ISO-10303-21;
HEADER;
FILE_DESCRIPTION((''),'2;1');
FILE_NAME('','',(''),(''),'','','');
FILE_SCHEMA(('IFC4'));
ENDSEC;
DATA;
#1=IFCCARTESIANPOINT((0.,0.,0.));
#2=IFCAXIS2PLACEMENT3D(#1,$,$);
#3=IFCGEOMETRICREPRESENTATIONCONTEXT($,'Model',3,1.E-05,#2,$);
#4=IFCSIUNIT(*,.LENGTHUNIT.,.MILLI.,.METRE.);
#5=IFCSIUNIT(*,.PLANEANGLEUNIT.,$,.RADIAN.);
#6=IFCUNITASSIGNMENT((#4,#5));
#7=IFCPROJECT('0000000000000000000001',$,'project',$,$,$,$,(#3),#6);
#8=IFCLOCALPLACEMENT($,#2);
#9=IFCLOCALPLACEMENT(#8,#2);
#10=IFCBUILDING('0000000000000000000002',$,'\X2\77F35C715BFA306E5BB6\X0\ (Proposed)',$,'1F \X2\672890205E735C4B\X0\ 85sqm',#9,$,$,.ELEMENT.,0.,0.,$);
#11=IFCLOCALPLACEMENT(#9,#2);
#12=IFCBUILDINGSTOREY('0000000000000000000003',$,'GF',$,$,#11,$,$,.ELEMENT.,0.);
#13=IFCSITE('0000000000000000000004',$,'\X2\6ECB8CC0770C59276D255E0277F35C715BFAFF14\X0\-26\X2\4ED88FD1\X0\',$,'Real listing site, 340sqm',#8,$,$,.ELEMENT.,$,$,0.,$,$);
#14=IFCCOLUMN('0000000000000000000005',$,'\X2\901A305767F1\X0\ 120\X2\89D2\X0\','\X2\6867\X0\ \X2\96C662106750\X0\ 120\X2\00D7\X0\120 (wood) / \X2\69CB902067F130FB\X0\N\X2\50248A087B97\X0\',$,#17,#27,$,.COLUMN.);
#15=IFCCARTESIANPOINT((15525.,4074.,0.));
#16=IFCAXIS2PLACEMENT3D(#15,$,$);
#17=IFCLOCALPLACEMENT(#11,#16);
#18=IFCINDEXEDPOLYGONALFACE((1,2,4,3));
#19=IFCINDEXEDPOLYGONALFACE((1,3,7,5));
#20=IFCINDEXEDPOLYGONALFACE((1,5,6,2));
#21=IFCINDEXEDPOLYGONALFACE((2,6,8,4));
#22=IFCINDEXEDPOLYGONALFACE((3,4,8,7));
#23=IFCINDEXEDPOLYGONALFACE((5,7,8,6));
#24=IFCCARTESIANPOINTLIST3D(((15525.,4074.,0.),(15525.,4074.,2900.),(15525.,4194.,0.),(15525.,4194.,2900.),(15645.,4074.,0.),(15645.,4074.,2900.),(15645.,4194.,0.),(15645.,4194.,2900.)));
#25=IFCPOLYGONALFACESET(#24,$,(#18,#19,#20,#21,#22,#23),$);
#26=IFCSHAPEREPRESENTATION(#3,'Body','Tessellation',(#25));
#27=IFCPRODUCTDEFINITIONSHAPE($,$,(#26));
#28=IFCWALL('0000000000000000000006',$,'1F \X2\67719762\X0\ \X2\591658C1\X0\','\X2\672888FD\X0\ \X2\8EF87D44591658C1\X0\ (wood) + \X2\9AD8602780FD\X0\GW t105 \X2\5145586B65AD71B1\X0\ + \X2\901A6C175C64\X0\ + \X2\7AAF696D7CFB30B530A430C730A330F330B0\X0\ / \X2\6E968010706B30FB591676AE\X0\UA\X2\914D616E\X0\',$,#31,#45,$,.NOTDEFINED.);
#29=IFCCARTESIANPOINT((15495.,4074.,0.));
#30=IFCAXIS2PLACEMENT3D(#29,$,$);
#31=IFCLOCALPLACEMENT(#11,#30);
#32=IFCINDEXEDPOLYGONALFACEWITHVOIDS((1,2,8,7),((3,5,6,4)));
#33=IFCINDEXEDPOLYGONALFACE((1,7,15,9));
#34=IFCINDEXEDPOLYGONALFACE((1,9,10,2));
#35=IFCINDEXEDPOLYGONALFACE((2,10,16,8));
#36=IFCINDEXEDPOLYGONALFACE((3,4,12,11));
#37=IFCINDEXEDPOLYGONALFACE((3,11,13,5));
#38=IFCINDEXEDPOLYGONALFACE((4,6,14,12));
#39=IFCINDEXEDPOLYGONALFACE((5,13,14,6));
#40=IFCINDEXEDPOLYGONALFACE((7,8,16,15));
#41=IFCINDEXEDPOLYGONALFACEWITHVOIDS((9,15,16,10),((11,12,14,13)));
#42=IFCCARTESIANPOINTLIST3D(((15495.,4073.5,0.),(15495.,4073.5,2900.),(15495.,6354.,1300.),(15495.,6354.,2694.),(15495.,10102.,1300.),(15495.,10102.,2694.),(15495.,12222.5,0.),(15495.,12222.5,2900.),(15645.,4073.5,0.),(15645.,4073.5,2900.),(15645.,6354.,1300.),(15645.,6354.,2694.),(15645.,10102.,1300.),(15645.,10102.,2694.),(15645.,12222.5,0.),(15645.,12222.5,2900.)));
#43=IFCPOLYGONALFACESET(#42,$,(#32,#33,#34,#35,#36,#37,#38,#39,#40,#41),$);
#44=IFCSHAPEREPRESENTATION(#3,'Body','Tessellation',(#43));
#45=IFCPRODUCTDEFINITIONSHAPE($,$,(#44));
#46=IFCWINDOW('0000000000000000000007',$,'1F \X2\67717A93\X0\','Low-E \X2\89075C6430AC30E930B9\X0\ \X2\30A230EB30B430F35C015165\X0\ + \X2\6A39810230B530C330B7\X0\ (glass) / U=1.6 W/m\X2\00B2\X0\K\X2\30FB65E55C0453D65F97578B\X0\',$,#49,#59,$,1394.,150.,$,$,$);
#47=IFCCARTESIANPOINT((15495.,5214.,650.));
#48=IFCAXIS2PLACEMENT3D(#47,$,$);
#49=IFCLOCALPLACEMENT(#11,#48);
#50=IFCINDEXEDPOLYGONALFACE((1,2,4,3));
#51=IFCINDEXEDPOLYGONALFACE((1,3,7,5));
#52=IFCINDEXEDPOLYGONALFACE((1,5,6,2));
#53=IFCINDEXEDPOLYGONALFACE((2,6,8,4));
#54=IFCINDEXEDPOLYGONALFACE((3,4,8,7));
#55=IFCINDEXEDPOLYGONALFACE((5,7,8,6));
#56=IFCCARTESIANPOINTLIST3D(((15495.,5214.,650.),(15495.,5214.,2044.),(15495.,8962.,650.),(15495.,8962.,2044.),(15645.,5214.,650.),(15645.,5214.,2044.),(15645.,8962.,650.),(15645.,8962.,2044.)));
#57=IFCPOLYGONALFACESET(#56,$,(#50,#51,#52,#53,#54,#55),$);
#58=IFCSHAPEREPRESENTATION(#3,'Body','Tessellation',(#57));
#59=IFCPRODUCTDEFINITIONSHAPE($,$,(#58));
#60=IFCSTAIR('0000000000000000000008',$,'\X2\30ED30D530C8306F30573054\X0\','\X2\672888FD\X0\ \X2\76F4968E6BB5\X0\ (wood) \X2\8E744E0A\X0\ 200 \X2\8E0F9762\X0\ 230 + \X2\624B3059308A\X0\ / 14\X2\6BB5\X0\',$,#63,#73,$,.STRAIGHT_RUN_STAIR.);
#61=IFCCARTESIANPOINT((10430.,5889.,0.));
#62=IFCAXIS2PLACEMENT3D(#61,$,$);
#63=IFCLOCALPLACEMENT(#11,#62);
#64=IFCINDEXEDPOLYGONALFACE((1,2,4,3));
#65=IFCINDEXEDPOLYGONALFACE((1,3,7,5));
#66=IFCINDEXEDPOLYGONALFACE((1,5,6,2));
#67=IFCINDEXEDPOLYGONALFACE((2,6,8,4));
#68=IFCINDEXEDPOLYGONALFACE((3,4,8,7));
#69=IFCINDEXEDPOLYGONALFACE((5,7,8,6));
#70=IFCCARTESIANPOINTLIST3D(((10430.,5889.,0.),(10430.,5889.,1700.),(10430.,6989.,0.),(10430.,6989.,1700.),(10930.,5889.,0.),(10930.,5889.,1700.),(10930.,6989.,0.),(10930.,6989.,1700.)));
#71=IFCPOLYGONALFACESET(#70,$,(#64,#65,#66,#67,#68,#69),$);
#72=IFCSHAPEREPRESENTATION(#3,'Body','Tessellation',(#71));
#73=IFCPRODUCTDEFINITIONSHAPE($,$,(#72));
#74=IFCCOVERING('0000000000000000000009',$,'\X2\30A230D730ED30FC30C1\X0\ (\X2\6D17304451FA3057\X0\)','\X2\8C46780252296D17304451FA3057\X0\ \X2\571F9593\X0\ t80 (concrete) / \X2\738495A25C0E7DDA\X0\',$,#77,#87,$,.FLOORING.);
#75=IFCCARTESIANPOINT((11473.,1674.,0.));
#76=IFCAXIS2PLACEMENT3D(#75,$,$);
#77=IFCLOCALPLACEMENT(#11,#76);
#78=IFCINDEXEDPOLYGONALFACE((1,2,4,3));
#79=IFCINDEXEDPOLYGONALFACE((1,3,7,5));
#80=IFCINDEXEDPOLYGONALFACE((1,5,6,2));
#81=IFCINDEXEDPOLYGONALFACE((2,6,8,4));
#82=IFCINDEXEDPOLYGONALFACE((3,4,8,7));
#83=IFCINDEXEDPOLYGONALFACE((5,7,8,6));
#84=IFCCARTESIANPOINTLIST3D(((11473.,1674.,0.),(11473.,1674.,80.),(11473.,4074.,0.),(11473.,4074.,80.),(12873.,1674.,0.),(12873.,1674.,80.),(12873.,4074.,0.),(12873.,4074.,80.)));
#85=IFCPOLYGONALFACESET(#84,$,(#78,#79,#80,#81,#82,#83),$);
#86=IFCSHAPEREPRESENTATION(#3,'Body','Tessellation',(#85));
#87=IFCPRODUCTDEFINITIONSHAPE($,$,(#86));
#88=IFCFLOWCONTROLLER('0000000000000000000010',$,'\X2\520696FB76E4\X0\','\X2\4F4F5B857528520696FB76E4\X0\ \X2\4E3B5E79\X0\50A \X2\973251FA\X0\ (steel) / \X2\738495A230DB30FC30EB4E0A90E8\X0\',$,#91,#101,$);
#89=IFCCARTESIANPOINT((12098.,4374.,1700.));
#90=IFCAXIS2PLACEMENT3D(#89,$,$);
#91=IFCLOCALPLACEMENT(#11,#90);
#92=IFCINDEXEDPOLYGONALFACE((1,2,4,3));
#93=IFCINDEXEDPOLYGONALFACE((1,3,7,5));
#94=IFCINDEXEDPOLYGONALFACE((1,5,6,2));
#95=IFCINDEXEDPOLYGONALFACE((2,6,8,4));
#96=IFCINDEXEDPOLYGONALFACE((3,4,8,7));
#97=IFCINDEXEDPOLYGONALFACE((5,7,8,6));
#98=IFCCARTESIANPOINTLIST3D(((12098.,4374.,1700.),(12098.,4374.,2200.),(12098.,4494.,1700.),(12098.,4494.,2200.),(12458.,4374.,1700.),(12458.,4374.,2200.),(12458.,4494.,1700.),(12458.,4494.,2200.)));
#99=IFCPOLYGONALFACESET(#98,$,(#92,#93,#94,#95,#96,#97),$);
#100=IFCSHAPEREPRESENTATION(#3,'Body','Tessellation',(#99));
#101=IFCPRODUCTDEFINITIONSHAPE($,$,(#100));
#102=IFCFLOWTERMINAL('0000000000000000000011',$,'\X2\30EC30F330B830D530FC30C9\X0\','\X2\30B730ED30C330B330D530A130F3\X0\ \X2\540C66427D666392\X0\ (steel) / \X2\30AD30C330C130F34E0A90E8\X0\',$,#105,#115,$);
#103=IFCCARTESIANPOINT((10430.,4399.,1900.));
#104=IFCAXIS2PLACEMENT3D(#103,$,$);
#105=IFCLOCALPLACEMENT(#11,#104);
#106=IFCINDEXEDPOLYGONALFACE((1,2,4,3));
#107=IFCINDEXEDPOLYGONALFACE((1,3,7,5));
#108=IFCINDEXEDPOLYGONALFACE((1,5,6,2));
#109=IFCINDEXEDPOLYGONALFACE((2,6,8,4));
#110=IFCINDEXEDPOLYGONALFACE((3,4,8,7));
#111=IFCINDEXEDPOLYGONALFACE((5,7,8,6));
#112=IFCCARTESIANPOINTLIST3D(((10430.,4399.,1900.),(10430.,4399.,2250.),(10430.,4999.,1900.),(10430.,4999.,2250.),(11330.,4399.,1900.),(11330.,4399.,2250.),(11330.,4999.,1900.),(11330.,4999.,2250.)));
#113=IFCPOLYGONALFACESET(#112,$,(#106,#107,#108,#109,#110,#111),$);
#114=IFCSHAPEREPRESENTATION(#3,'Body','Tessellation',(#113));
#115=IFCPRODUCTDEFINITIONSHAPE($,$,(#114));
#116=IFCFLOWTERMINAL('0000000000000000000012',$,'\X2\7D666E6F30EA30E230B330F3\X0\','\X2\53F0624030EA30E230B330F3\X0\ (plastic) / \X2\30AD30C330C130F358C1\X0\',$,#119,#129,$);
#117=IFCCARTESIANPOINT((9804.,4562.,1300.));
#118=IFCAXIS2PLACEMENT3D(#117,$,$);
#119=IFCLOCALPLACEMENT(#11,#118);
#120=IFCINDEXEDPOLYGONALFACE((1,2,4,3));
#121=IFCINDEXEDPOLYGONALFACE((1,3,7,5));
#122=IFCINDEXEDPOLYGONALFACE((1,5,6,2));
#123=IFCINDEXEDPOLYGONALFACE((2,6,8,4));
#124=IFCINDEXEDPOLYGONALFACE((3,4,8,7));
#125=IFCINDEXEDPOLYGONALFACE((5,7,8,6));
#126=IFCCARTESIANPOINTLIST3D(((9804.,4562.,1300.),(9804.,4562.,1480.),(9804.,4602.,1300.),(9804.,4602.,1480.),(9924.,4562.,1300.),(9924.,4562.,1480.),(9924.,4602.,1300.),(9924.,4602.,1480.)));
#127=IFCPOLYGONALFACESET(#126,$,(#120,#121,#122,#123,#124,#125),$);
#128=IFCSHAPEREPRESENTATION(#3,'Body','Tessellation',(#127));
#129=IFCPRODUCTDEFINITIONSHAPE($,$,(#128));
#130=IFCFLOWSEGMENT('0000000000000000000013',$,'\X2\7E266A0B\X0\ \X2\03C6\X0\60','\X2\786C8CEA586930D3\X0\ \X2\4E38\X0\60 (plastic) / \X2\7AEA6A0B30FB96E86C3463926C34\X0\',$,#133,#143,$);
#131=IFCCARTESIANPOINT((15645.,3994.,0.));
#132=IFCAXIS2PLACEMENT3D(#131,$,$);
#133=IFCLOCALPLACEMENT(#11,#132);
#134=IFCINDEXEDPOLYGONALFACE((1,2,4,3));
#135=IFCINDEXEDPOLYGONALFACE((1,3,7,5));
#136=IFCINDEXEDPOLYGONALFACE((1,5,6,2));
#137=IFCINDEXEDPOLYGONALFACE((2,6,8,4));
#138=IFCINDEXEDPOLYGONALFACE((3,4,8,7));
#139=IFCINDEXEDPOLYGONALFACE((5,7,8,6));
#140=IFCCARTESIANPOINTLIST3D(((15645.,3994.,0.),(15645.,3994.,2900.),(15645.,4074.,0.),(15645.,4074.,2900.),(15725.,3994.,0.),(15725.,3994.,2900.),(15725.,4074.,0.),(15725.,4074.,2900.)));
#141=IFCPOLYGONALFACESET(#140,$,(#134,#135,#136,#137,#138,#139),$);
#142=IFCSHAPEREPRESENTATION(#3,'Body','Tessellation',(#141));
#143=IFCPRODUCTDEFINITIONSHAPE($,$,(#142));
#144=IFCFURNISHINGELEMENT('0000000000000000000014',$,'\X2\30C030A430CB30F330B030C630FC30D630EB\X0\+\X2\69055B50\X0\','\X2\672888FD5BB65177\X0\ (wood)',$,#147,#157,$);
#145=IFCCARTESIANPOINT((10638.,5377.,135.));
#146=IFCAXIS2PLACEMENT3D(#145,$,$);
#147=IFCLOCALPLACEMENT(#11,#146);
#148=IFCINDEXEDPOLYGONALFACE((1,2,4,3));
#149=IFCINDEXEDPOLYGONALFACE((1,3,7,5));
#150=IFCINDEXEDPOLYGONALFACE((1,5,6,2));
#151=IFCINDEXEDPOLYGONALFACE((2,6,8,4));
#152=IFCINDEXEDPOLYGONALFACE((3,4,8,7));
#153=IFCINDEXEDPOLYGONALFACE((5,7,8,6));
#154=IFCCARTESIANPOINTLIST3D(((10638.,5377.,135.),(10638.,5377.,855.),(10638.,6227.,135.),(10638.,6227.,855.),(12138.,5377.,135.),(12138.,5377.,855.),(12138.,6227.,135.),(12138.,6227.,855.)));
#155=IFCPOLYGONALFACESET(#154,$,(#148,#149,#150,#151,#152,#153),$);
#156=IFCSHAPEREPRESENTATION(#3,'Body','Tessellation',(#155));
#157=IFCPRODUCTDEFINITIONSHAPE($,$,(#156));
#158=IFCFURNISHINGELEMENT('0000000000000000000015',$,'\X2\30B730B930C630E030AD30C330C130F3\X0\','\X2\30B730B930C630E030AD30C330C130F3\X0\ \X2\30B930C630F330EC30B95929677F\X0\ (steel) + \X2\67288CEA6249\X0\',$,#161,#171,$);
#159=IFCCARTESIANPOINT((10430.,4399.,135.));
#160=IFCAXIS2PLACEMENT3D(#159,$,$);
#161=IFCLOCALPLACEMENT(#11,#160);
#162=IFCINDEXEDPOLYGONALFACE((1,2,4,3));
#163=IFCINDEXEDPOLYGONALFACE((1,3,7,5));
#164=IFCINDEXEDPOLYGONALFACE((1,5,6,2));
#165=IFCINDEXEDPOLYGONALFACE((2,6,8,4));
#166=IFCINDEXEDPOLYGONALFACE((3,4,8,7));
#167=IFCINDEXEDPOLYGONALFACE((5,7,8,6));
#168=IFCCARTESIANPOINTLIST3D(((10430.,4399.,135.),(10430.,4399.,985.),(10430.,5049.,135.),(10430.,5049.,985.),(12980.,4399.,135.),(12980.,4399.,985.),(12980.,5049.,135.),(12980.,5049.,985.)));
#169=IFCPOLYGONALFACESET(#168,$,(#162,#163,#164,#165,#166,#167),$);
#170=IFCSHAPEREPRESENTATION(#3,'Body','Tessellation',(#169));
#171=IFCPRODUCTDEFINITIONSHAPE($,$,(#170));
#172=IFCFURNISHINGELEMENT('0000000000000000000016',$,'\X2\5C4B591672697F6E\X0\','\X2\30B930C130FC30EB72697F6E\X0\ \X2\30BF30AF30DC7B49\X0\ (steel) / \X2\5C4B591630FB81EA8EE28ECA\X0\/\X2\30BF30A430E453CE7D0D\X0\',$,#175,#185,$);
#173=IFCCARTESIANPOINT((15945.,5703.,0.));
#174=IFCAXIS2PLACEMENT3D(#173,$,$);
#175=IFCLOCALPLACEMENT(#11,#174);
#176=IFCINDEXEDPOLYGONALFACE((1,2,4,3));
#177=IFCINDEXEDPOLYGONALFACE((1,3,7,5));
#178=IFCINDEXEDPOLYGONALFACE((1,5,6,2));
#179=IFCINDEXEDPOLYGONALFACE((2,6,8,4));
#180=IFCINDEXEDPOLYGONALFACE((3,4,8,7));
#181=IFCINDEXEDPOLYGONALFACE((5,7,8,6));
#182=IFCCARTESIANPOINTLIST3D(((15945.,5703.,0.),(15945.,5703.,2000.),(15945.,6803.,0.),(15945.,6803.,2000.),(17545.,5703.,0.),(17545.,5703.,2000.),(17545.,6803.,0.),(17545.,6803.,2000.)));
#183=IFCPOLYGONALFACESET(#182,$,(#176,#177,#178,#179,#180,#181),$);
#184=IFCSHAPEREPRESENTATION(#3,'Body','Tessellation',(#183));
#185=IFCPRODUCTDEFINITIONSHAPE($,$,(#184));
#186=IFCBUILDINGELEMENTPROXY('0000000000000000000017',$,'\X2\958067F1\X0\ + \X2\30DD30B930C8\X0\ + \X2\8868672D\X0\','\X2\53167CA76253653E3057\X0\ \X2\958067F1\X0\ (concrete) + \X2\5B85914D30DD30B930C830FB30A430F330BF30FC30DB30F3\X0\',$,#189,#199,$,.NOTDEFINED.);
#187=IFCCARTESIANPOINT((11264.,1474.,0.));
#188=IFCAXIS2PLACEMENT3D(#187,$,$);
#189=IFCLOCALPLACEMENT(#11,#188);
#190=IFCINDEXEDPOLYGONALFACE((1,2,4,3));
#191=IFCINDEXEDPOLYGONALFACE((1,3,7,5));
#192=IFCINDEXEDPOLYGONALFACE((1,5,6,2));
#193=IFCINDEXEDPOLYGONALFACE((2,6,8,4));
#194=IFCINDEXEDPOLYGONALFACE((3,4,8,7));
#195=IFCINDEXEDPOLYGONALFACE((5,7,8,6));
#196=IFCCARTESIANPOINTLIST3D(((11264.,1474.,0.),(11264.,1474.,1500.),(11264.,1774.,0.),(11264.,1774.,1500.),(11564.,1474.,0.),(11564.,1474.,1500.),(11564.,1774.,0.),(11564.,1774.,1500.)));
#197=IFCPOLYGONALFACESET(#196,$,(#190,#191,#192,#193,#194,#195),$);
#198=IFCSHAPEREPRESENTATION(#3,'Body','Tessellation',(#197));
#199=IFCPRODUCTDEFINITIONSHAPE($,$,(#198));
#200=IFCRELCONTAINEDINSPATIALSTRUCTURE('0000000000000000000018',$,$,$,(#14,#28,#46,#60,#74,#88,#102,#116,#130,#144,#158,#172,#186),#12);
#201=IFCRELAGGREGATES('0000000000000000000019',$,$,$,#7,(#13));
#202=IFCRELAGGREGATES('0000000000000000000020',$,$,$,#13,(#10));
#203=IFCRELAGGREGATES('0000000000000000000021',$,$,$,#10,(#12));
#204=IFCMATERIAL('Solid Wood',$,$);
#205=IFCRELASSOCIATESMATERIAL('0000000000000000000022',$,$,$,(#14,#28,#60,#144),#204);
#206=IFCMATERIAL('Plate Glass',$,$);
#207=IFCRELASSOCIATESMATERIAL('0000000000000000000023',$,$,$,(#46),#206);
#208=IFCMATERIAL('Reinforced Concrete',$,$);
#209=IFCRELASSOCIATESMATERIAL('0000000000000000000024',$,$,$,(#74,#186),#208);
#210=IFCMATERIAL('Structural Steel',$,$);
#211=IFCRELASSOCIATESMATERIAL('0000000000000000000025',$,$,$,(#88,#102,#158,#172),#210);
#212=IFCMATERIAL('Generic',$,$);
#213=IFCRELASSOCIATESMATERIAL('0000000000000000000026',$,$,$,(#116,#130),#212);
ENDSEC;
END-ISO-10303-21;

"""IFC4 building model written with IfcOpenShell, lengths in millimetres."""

from ifc_helpers import new_model, si_unit, frame, frame_2d, origin, place, context, project, spatial, rectangle, extrude, material, element, fill, save


model = new_model("IFC4")

# Units and contexts
model_context = context("Model", 3, precision=1e-05, world=origin())
ifc_project = project(units=[si_unit("LENGTHUNIT", "METRE", prefix="MILLI"), si_unit("PLANEANGLEUNIT", "RADIAN")], contexts=[model_context])

# Site, building, storey
site_placement = place(None, origin())
site = spatial("IfcSite", under=ifc_project, at=site_placement, Name="滋賀県大津市石山寺４-26付近", ObjectType="Real listing site, 340sqm", CompositionType="ELEMENT", RefElevation=0.0)
building_placement = place(site_placement, origin())
building = spatial("IfcBuilding", under=site, at=building_placement, Name="石山寺の家 (Proposed)", ObjectType="1F 木造平屋 85sqm", CompositionType="ELEMENT", ElevationOfRefHeight=0.0, ElevationOfTerrain=0.0)
storey_placement = place(building_placement, origin())
storey = spatial("IfcBuildingStorey", under=building, at=storey_placement, Name="GF", CompositionType="ELEMENT", Elevation=0.0)

# Column
ifc_material_1 = material(Name="Solid Wood")
column_1_placement = place(storey_placement, frame((15525.0, 4074.0, 0.0)))
element("IfcColumn", 1, at=column_1_placement, inside=storey, material=ifc_material_1, Name="通し柱 120角", Description="桧 集成材 120×120 (wood) / 構造柱・N値計算", PredefinedType="COLUMN", context=model_context, shape_type="SweptSolid", body=[
    extrude(rectangle(XDim=120.0, YDim=120.0, at=frame_2d((60.0, 60.0))), frame((15525.0, 4074.0, 0.0)), (0.0, 0.0, 1.0), 2900.0),
])

# Wall, opening, window
wall_1_placement = place(storey_placement, frame((15495.0, 4074.0, 0.0)))
wall_1 = element("IfcWall", 2, at=wall_1_placement, inside=storey, material=ifc_material_1, Name="1F 東面 外壁", Description="木製 軸組外壁 (wood) + 高性能GW t105 充填断熱 + 通気層 + 窯業系サイディング / 準耐火・外皮UA配慮", PredefinedType="NOTDEFINED", context=model_context, shape_type="SweptSolid", body=[
    extrude(rectangle(XDim=150.0, YDim=8149.0, at=frame_2d((75.0, 4074.0))), frame((15495.0, 4074.0, 0.0)), (0.0, 0.0, 1.0), 2900.0),
])
opening_placement = place(storey_placement, frame((15495.0, 5214.0, 650.0)))
opening = element("IfcOpeningElement", 3, at=opening_placement, cuts=wall_1, PredefinedType="NOTDEFINED", context=model_context, shape_type="SweptSolid", body=[
    extrude(rectangle(XDim=150.0, YDim=3748.0, at=frame_2d((75.0, 1874.0))), frame((15495.0, 5214.0, 650.0)), (0.0, 0.0, 1.0), 1394.0),
])
ifc_material_2 = material(Name="Plate Glass")
window_placement = place(storey_placement, frame((15495.0, 5214.0, 650.0)))
window = element("IfcWindow", 4, at=window_placement, inside=storey, material=ifc_material_2, Name="1F 東窓", Description="Low-E 複層ガラス アルゴン封入 + 樹脂サッシ (glass) / U=1.6 W/m²K・日射取得型", OverallHeight=1394.0, OverallWidth=150.0, context=model_context, shape_type="SweptSolid", body=[
    extrude(rectangle(XDim=150.0, YDim=3748.0, at=frame_2d((75.0, 1874.0))), frame((15495.0, 5214.0, 650.0)), (0.0, 0.0, 1.0), 1394.0),
])
fill(opening, window)

# Stair
stair_placement = place(storey_placement, frame((10430.0, 5889.0, 0.0)))
element("IfcStair", 5, at=stair_placement, inside=storey, material=ifc_material_1, Name="ロフトはしご", Description="木製 直階段 (wood) 蹴上 200 踏面 230 + 手すり / 14段", PredefinedType="STRAIGHT_RUN_STAIR", context=model_context, shape_type="SweptSolid", body=[
    extrude(rectangle(XDim=500.0, YDim=1100.0, at=frame_2d((250.0, 550.0))), frame((10430.0, 5889.0, 0.0)), (0.0, 0.0, 1.0), 1700.0),
])

# Covering
ifc_material_3 = material(Name="Reinforced Concrete")
covering_placement = place(storey_placement, frame((11473.0, 1674.0, 0.0)))
element("IfcCovering", 6, at=covering_placement, inside=storey, material=ifc_material_3, Name="アプローチ (洗い出し)", Description="豆砂利洗い出し 土間 t80 (concrete) / 玄関導線", PredefinedType="FLOORING", context=model_context, shape_type="SweptSolid", body=[
    extrude(rectangle(XDim=1400.0, YDim=2400.0, at=frame_2d((700.0, 1200.0))), frame((11473.0, 1674.0, 0.0)), (0.0, 0.0, 1.0), 80.0),
])

# Flow controller
ifc_material_4 = material(Name="Structural Steel")
flow_controller_placement = place(storey_placement, frame((12098.0, 4374.0, 1700.0)))
element("IfcFlowController", 7, at=flow_controller_placement, inside=storey, material=ifc_material_4, Name="分電盤", Description="住宅用分電盤 主幹50A 露出 (steel) / 玄関ホール上部", context=model_context, shape_type="SweptSolid", body=[
    extrude(rectangle(XDim=360.0, YDim=120.0, at=frame_2d((180.0, 60.0))), frame((12098.0, 4374.0, 1700.0)), (0.0, 0.0, 1.0), 500.0),
])

# Flow terminals
flow_terminal_1_placement = place(storey_placement, frame((10430.0, 4399.0, 1900.0)))
element("IfcFlowTerminal", 8, at=flow_terminal_1_placement, inside=storey, material=ifc_material_4, Name="レンジフード", Description="シロッコファン 同時給排 (steel) / キッチン上部", context=model_context, shape_type="SweptSolid", body=[
    extrude(rectangle(XDim=900.0, YDim=600.0, at=frame_2d((450.0, 300.0))), frame((10430.0, 4399.0, 1900.0)), (0.0, 0.0, 1.0), 350.0),
])
ifc_material_5 = material(Name="Generic")
flow_terminal_2_placement = place(storey_placement, frame((9804.0, 4562.0, 1300.0)))
element("IfcFlowTerminal", 9, at=flow_terminal_2_placement, inside=storey, material=ifc_material_5, Name="給湯リモコン", Description="台所リモコン (plastic) / キッチン壁", context=model_context, shape_type="SweptSolid", body=[
    extrude(rectangle(XDim=120.0, YDim=40.0, at=frame_2d((60.0, 20.0))), frame((9804.0, 4562.0, 1300.0)), (0.0, 0.0, 1.0), 180.0),
])

# Flow segment
flow_segment_placement = place(storey_placement, frame((15645.0, 3994.0, 0.0)))
element("IfcFlowSegment", 10, at=flow_segment_placement, inside=storey, material=ifc_material_5, Name="縦樋 φ60", Description="硬質塩ビ 丸60 (plastic) / 竪樋・雨水排水", context=model_context, shape_type="SweptSolid", body=[
    extrude(rectangle(XDim=80.0, YDim=80.0, at=frame_2d((40.0, 40.0))), frame((15645.0, 3994.0, 0.0)), (0.0, 0.0, 1.0), 2900.0),
])

# Furnishing elements
furnishing_1_placement = place(storey_placement, frame((10638.0, 5377.0, 135.0)))
element("IfcFurnishingElement", 11, at=furnishing_1_placement, inside=storey, material=ifc_material_1, Name="ダイニングテーブル+椅子", Description="木製家具 (wood)", context=model_context, shape_type="SweptSolid", body=[
    extrude(rectangle(XDim=1500.0, YDim=850.0, at=frame_2d((750.0, 425.0))), frame((10638.0, 5377.0, 135.0)), (0.0, 0.0, 1.0), 720.0),
])
furnishing_2_placement = place(storey_placement, frame((10430.0, 4399.0, 135.0)))
element("IfcFurnishingElement", 12, at=furnishing_2_placement, inside=storey, material=ifc_material_4, Name="システムキッチン", Description="システムキッチン ステンレス天板 (steel) + 木質扉", context=model_context, shape_type="SweptSolid", body=[
    extrude(rectangle(XDim=2550.0, YDim=650.0, at=frame_2d((1275.0, 325.0))), frame((10430.0, 4399.0, 135.0)), (0.0, 0.0, 1.0), 850.0),
])
furnishing_3_placement = place(storey_placement, frame((15945.0, 5703.0, 0.0)))
element("IfcFurnishingElement", 13, at=furnishing_3_placement, inside=storey, material=ifc_material_4, Name="屋外物置", Description="スチール物置 タクボ等 (steel) / 屋外・自転車/タイヤ収納", context=model_context, shape_type="SweptSolid", body=[
    extrude(rectangle(XDim=1600.0, YDim=1100.0, at=frame_2d((800.0, 550.0))), frame((15945.0, 5703.0, 0.0)), (0.0, 0.0, 1.0), 2000.0),
])

# Building element proxy
proxy_placement = place(storey_placement, frame((11264.0, 1474.0, 0.0)))
element("IfcBuildingElementProxy", 14, at=proxy_placement, inside=storey, material=ifc_material_3, Name="門柱 + ポスト + 表札", Description="化粧打放し 門柱 (concrete) + 宅配ポスト・インターホン", PredefinedType="NOTDEFINED", context=model_context, shape_type="SweptSolid", body=[
    extrude(rectangle(XDim=300.0, YDim=300.0, at=frame_2d((150.0, 150.0))), frame((11264.0, 1474.0, 0.0)), (0.0, 0.0, 1.0), 1500.0),
])

save(model, "model.ifc")
